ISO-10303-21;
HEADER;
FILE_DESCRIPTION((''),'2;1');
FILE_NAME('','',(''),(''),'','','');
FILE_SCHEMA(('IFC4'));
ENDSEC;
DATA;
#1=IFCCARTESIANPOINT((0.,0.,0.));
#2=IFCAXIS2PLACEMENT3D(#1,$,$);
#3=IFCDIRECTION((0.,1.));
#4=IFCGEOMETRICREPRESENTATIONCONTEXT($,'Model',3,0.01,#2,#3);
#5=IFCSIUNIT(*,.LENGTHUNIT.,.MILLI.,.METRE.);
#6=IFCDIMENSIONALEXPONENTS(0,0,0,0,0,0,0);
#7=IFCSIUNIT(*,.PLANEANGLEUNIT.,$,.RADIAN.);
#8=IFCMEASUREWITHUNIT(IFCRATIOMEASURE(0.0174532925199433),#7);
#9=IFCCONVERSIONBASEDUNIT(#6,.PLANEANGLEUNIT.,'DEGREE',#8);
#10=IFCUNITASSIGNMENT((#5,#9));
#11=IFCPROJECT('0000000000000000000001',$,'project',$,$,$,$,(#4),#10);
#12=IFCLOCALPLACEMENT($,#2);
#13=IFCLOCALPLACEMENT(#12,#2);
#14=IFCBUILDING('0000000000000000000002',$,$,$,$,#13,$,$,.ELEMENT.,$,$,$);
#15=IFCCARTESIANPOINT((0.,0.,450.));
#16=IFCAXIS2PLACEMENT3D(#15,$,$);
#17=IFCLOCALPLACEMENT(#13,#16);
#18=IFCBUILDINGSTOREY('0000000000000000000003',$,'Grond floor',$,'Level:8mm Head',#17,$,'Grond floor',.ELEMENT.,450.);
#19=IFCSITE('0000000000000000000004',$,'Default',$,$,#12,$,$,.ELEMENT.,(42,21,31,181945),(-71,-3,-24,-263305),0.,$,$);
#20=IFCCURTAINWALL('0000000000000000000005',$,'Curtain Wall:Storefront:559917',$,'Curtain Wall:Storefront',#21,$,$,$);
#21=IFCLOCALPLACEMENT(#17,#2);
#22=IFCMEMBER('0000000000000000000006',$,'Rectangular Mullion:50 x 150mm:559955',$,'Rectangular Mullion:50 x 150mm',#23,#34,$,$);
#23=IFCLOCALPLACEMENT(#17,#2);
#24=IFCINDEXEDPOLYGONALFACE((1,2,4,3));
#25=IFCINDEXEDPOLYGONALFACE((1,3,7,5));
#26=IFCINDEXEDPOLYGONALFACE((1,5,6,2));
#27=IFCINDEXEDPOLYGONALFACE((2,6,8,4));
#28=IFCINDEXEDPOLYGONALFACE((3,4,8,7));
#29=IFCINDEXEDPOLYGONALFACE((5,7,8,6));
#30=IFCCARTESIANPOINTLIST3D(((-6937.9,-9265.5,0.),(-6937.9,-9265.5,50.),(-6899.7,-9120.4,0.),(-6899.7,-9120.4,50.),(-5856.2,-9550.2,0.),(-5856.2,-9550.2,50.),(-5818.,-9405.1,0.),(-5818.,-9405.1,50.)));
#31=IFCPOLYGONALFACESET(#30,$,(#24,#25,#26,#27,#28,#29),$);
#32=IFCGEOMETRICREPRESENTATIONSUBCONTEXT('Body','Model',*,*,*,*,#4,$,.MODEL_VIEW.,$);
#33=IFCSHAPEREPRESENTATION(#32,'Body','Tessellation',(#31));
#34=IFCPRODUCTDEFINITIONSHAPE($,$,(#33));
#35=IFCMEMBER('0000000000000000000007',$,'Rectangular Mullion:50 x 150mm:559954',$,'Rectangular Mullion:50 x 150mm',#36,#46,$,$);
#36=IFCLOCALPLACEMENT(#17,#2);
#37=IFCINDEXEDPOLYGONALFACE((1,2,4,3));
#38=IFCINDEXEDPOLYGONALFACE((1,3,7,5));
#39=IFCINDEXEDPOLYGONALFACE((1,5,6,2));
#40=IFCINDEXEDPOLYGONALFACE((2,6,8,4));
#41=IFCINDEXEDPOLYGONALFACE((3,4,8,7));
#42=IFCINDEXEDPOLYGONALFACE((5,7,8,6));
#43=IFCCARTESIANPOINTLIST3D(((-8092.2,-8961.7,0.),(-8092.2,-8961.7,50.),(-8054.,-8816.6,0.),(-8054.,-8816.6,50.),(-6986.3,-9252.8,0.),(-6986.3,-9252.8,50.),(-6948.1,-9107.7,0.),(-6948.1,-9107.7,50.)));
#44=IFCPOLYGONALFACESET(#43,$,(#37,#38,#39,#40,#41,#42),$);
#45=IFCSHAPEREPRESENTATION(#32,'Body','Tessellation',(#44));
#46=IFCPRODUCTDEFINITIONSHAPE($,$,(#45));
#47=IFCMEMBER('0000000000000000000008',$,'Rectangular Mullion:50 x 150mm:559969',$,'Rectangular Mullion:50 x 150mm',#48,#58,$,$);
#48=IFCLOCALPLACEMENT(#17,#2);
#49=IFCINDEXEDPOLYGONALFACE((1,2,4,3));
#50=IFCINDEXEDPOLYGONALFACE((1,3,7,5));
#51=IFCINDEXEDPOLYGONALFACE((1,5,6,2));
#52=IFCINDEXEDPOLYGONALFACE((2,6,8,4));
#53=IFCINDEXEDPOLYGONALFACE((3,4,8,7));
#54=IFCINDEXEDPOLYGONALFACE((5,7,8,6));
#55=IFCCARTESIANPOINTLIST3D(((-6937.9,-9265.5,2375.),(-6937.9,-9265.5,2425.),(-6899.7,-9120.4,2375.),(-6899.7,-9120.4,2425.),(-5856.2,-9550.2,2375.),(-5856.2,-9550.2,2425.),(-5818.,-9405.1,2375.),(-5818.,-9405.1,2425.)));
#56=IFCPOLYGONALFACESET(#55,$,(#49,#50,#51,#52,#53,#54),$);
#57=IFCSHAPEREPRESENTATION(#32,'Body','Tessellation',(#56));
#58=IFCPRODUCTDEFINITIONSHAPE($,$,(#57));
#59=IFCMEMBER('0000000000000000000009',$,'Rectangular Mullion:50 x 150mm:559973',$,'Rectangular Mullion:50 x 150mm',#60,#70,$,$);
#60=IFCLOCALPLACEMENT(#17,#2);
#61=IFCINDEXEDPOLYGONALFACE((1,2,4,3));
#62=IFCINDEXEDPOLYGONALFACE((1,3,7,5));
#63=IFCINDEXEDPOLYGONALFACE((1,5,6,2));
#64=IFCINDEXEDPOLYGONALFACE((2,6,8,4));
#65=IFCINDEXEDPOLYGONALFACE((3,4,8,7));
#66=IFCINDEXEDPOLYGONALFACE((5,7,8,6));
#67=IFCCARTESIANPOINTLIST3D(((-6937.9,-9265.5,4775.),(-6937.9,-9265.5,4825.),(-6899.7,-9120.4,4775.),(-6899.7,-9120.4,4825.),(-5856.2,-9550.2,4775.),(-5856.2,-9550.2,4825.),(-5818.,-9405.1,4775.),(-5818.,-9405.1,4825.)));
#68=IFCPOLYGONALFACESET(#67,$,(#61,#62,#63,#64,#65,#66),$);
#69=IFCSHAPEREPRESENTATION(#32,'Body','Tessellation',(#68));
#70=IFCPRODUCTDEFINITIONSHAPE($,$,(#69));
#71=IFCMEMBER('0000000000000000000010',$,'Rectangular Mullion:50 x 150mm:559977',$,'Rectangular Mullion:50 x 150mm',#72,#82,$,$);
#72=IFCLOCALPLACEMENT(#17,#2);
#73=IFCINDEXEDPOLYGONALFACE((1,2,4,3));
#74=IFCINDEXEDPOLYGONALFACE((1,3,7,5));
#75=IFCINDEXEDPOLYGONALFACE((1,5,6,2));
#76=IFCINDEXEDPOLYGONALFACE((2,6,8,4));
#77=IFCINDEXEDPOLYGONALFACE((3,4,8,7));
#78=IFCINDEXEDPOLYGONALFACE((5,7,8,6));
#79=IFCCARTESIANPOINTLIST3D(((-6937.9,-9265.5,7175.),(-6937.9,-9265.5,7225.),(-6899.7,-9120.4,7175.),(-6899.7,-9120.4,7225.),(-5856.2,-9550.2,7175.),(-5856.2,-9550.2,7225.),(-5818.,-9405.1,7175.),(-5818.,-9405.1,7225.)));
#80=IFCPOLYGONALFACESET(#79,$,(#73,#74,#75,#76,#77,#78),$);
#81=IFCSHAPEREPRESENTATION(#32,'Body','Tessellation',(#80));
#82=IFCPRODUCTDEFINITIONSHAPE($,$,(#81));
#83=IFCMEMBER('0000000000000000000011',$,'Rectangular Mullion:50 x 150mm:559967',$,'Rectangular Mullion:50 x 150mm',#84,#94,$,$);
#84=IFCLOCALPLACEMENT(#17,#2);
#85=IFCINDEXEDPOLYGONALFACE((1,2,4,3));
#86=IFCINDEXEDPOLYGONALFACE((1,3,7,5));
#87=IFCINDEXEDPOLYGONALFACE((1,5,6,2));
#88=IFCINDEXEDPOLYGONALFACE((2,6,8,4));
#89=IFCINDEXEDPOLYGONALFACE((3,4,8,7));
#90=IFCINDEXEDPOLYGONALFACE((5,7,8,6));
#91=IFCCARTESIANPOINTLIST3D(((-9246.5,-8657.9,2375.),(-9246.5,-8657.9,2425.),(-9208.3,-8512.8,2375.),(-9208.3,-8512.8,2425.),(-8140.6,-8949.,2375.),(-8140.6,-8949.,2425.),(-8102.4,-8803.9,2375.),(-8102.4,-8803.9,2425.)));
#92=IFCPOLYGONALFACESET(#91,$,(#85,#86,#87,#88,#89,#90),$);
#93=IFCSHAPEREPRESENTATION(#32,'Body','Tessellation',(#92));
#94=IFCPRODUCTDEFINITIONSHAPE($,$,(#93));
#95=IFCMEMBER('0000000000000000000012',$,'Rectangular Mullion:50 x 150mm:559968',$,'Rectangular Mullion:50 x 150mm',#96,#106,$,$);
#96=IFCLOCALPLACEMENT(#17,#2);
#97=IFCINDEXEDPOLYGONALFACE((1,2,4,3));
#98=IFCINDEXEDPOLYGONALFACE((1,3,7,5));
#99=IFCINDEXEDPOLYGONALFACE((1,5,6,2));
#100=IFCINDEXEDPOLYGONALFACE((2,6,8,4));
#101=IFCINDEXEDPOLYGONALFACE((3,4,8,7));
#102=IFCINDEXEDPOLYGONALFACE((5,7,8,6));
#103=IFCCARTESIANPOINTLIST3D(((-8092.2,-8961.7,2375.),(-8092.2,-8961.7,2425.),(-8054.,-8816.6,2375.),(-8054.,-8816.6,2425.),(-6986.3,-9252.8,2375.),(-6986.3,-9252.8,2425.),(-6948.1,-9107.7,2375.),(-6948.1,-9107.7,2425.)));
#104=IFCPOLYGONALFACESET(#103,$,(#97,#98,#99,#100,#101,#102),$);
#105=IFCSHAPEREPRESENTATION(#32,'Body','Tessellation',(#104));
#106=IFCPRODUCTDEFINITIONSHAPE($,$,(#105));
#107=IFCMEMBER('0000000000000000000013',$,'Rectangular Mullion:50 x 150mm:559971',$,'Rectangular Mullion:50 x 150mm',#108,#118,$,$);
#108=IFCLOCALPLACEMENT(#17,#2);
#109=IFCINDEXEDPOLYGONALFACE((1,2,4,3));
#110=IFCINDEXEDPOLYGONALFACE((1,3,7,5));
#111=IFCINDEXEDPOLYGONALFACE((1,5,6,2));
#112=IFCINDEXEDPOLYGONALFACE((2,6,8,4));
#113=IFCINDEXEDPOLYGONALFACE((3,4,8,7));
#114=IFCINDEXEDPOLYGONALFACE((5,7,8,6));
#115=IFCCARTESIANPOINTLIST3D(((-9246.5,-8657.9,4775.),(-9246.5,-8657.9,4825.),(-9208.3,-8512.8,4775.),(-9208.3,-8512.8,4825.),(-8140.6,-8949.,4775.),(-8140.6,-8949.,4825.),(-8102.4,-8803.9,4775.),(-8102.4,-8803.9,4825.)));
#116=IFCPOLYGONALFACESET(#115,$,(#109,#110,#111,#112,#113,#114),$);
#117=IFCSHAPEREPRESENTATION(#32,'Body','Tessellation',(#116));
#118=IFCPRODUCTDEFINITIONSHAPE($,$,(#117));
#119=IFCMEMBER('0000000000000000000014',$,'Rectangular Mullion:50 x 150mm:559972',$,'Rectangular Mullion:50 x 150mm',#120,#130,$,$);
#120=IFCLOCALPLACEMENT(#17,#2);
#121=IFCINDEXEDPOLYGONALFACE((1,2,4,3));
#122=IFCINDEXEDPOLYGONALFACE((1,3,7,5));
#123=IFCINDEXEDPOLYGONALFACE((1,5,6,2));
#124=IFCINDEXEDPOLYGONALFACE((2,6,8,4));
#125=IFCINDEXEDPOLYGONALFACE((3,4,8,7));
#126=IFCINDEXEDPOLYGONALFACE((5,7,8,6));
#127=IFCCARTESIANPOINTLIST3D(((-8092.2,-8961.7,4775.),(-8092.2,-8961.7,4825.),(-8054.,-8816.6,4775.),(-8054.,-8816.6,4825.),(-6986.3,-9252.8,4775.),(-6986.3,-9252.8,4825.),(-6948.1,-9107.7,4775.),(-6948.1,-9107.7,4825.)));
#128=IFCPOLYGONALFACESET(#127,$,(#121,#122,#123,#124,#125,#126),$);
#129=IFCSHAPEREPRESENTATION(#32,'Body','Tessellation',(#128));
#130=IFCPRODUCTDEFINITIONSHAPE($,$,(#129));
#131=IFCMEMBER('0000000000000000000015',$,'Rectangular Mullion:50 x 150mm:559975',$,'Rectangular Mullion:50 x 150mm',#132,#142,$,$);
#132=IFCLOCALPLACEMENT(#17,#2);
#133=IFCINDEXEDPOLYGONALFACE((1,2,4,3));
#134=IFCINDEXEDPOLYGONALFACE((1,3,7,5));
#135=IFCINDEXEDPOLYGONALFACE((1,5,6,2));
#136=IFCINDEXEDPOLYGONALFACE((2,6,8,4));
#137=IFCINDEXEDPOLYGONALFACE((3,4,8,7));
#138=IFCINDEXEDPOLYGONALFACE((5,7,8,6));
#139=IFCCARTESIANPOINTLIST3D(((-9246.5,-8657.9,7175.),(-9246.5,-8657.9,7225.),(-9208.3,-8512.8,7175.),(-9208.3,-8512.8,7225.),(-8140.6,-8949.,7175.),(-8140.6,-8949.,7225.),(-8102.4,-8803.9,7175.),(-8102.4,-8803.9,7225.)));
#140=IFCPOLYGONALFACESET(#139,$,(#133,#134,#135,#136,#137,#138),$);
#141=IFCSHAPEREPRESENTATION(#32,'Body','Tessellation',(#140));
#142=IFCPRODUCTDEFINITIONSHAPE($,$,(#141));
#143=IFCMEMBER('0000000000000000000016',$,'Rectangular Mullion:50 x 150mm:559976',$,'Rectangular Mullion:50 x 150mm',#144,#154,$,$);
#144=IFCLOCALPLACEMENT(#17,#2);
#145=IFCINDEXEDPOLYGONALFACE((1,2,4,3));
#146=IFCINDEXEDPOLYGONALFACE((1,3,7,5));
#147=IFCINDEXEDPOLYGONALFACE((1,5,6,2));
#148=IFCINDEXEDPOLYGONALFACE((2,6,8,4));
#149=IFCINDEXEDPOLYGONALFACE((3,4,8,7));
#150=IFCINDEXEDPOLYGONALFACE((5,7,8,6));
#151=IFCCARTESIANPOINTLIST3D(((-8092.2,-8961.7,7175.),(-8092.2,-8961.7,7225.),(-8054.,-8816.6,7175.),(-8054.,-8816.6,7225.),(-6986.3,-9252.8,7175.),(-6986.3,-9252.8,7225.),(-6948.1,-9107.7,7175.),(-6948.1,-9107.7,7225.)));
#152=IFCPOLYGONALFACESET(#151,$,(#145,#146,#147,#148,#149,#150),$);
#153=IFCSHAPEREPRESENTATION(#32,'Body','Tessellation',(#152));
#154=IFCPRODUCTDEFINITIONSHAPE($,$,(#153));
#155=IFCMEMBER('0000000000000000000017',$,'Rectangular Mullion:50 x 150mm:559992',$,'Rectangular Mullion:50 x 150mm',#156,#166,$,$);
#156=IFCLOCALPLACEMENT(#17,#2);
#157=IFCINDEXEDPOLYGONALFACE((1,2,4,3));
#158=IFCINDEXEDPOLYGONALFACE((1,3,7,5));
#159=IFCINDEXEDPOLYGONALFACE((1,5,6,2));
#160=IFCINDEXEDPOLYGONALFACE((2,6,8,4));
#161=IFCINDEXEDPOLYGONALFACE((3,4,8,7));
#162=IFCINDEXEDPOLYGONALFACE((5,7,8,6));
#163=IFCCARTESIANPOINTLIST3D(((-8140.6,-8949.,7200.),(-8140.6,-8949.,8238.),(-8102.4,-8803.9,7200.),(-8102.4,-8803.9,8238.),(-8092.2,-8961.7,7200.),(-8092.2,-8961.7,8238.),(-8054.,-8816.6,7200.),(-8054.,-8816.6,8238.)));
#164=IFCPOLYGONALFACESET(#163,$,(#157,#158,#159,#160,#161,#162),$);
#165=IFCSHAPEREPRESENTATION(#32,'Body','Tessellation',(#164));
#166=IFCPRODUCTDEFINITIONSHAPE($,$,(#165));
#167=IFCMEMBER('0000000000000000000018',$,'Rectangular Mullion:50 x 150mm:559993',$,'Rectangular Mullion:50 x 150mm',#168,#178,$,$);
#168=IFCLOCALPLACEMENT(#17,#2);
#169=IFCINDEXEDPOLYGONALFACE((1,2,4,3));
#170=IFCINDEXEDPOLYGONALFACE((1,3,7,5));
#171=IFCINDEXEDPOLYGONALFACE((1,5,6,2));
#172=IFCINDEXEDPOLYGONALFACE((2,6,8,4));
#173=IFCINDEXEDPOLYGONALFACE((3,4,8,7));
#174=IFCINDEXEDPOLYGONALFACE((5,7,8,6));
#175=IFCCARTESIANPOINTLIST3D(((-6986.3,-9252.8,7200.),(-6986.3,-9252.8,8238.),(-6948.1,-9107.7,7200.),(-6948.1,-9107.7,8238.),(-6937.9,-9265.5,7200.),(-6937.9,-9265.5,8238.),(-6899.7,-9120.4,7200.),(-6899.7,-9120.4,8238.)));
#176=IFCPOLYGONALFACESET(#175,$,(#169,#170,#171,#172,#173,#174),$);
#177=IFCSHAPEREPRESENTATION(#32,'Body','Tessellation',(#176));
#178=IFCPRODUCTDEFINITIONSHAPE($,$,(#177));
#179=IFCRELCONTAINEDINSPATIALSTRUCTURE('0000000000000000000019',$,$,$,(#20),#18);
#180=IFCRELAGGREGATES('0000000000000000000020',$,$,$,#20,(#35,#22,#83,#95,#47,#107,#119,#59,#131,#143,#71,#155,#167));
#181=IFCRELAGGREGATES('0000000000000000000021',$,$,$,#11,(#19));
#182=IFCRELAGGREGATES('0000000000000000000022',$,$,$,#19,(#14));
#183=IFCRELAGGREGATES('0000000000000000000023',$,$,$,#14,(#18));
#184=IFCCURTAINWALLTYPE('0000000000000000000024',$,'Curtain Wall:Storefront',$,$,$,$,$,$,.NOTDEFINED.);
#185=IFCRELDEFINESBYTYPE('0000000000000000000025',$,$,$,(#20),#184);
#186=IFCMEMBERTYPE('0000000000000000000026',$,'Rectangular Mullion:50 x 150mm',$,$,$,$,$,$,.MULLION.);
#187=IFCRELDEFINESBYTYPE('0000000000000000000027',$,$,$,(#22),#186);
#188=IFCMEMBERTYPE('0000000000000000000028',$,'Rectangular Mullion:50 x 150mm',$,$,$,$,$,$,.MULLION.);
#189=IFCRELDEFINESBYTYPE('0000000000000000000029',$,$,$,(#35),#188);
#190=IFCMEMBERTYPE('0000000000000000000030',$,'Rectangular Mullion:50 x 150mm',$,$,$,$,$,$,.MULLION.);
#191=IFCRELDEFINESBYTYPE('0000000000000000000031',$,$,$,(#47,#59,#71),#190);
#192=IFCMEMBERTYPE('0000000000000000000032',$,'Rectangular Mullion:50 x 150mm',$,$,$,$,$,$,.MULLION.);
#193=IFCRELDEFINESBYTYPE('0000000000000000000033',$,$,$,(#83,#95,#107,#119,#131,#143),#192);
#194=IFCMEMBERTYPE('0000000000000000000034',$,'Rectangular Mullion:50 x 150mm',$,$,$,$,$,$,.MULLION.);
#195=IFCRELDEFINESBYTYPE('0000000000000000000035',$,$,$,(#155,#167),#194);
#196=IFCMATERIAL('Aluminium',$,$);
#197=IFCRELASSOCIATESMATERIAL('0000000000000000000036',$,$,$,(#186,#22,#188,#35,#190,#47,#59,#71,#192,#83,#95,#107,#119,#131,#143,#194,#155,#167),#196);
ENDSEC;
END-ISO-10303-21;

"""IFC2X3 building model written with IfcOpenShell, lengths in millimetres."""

from ifc_helpers import new_model, entity, si_unit, converted_unit, direction, frame, frame_2d, origin, origin_2d_with_axis, place, context, subcontext, project, spatial, rectangle, extrude, source, transform, mapped, material, type_object, type_shapes, element, aggregate, save


model = new_model("IFC2X3")

# Units and contexts
model_context = context("Model", 3, precision=0.01, world=origin(), true_north=direction((0.0, 1.0)))
body_context = subcontext(model_context, "Body", "Model", "MODEL_VIEW")
ifc_project = project(units=[si_unit("LENGTHUNIT", "METRE", prefix="MILLI"), converted_unit("PLANEANGLEUNIT", "DEGREE", entity("IfcRatioMeasure", 0.0174532925199433), si_unit("PLANEANGLEUNIT", "RADIAN"), dimensions=[0, 0, 0, 0, 0, 0, 0])], contexts=[model_context])

# Site, building, storey
site_placement = place(None, origin())
site = spatial("IfcSite", under=ifc_project, at=site_placement, Name="Default", CompositionType="ELEMENT", RefLatitude=(42, 21, 31, 181945), RefLongitude=(-71, -3, -24, -263305), RefElevation=0.0)
building_placement = place(site_placement, origin())
building = spatial("IfcBuilding", under=site, at=building_placement, CompositionType="ELEMENT")
storey_placement = place(building_placement, frame((0.0, 0.0, 450.0)))
storey = spatial("IfcBuildingStorey", under=building, at=storey_placement, Name="Grond floor", ObjectType="Level:8mm Head", LongName="Grond floor", CompositionType="ELEMENT", Elevation=450.0)

# Curtain wall, members
curtain_wall_type = type_object("IfcCurtainWallType", Name="Curtain Wall:Storefront", PredefinedType="NOTDEFINED")
curtain_wall_placement = place(storey_placement, frame((0.0, 0.0, -450.0)))
curtain_wall = element("IfcCurtainWall", 1, at=curtain_wall_placement, inside=storey, type_object=curtain_wall_type, Name="Curtain Wall:Storefront:559917", ObjectType="Curtain Wall:Storefront")
ifc_material_1 = material(Name="Aluminium")
member_type_1 = type_object("IfcMemberType", Name="Rectangular Mullion:50 x 150mm", PredefinedType="MULLION", material=ifc_material_1)
shared_shape_1 = source(origin(), body_context, "Body", "SweptSolid", [
    extrude(rectangle(XDim=150.0, YDim=50.0, at=origin_2d_with_axis()), frame((-25.0, 0.0, -1118.6), z_axis=(0.0, 0.0, 1.0), x_axis=(0.0, -1.0, 0.0)), (0.0, 0.0, 1.0), 1118.6),
])
type_shapes(member_type_1, [shared_shape_1])
member_1_placement = place(storey_placement, frame((-6918.8, -9193.0, 0.0), z_axis=(-0.967067, 0.25452, 0.0), x_axis=(0.0, 0.0, -1.0)))
member_1 = element("IfcMember", 2, at=member_1_placement, type_object=member_type_1, material=ifc_material_1, Name="Rectangular Mullion:50 x 150mm:559955", ObjectType="Rectangular Mullion:50 x 150mm", context=body_context, shape_type="MappedRepresentation", body=[
    mapped(shared_shape_1, transform((0.0, 0.0, 0.0), scale=1.0)),
])
member_type_2 = type_object("IfcMemberType", Name="Rectangular Mullion:50 x 150mm", PredefinedType="MULLION", material=ifc_material_1)
shared_shape_2 = source(origin(), body_context, "Body", "SweptSolid", [
    extrude(rectangle(XDim=150.0, YDim=50.0, at=frame_2d((0.0, 0.0), x_axis=(1.0, 0.0))), frame((-25.0, 0.0, -1143.6), z_axis=(0.0, 0.0, 1.0), x_axis=(0.0, -1.0, 0.0)), (0.0, 0.0, 1.0), 1143.6),
])
type_shapes(member_type_2, [shared_shape_2])
member_2_placement = place(storey_placement, frame((-8073.1, -8889.2, 0.0), z_axis=(-0.967067, 0.25452, 0.0), x_axis=(0.0, 0.0, -1.0)))
member_2 = element("IfcMember", 3, at=member_2_placement, type_object=member_type_2, material=ifc_material_1, Name="Rectangular Mullion:50 x 150mm:559954", ObjectType="Rectangular Mullion:50 x 150mm", context=body_context, shape_type="MappedRepresentation", body=[
    mapped(shared_shape_2, transform((0.0, 0.0, 0.0), scale=1.0)),
])
member_type_3 = type_object("IfcMemberType", Name="Rectangular Mullion:50 x 150mm", PredefinedType="MULLION", material=ifc_material_1)
shared_shape_3 = source(origin(), body_context, "Body", "SweptSolid", [
    extrude(rectangle(XDim=150.0, YDim=50.0, at=origin_2d_with_axis()), frame((0.0, 0.0, -1118.6), z_axis=(0.0, 0.0, 1.0), x_axis=(0.0, -1.0, 0.0)), (0.0, 0.0, 1.0), 1118.6),
])
type_shapes(member_type_3, [shared_shape_3])
member_3_placement = place(storey_placement, frame((-5837.1, -9477.7, 2400.0), z_axis=(0.967067, -0.25452, 0.0), x_axis=(0.0, 0.0, 1.0)))
member_3 = element("IfcMember", 4, at=member_3_placement, type_object=member_type_3, material=ifc_material_1, Name="Rectangular Mullion:50 x 150mm:559969", ObjectType="Rectangular Mullion:50 x 150mm", context=body_context, shape_type="MappedRepresentation", body=[
    mapped(shared_shape_3, transform((0.0, 0.0, 0.0), scale=1.0)),
])
member_4_placement = place(storey_placement, frame((-5837.1, -9477.7, 4800.0), z_axis=(0.967067, -0.25452, 0.0), x_axis=(0.0, 0.0, 1.0)))
member_4 = element("IfcMember", 5, at=member_4_placement, type_object=member_type_3, material=ifc_material_1, Name="Rectangular Mullion:50 x 150mm:559973", ObjectType="Rectangular Mullion:50 x 150mm", context=body_context, shape_type="MappedRepresentation", body=[
    mapped(shared_shape_3, transform((0.0, 0.0, 0.0), scale=1.0)),
])
member_5_placement = place(storey_placement, frame((-5837.1, -9477.7, 7200.0), z_axis=(0.967067, -0.25452, 0.0), x_axis=(0.0, 0.0, 1.0)))
member_5 = element("IfcMember", 6, at=member_5_placement, type_object=member_type_3, material=ifc_material_1, Name="Rectangular Mullion:50 x 150mm:559977", ObjectType="Rectangular Mullion:50 x 150mm", context=body_context, shape_type="MappedRepresentation", body=[
    mapped(shared_shape_3, transform((0.0, 0.0, 0.0), scale=1.0)),
])
member_type_4 = type_object("IfcMemberType", Name="Rectangular Mullion:50 x 150mm", PredefinedType="MULLION", material=ifc_material_1)
shared_shape_4 = source(origin(), body_context, "Body", "SweptSolid", [
    extrude(rectangle(XDim=150.0, YDim=50.0, at=frame_2d((0.0, 0.0), x_axis=(1.0, 0.0))), frame((0.0, 0.0, -1143.6), z_axis=(0.0, 0.0, 1.0), x_axis=(0.0, -1.0, 0.0)), (0.0, 0.0, 1.0), 1143.6),
])
type_shapes(member_type_4, [shared_shape_4])
member_6_placement = place(storey_placement, frame((-8121.5, -8876.4, 2400.0), z_axis=(0.967067, -0.25452, 0.0), x_axis=(0.0, 0.0, 1.0)))
member_6 = element("IfcMember", 7, at=member_6_placement, type_object=member_type_4, material=ifc_material_1, Name="Rectangular Mullion:50 x 150mm:559967", ObjectType="Rectangular Mullion:50 x 150mm", context=body_context, shape_type="MappedRepresentation", body=[
    mapped(shared_shape_4, transform((0.0, 0.0, 0.0), scale=1.0)),
])
member_7_placement = place(storey_placement, frame((-6967.2, -9180.2, 2400.0), z_axis=(0.967067, -0.25452, 0.0), x_axis=(0.0, 0.0, 1.0)))
member_7 = element("IfcMember", 8, at=member_7_placement, type_object=member_type_4, material=ifc_material_1, Name="Rectangular Mullion:50 x 150mm:559968", ObjectType="Rectangular Mullion:50 x 150mm", context=body_context, shape_type="MappedRepresentation", body=[
    mapped(shared_shape_4, transform((0.0, 0.0, 0.0), scale=1.0)),
])
member_8_placement = place(storey_placement, frame((-8121.5, -8876.4, 4800.0), z_axis=(0.967067, -0.25452, 0.0), x_axis=(0.0, 0.0, 1.0)))
member_8 = element("IfcMember", 9, at=member_8_placement, type_object=member_type_4, material=ifc_material_1, Name="Rectangular Mullion:50 x 150mm:559971", ObjectType="Rectangular Mullion:50 x 150mm", context=body_context, shape_type="MappedRepresentation", body=[
    mapped(shared_shape_4, transform((0.0, 0.0, 0.0), scale=1.0)),
])
member_9_placement = place(storey_placement, frame((-6967.2, -9180.2, 4800.0), z_axis=(0.967067, -0.25452, 0.0), x_axis=(0.0, 0.0, 1.0)))
member_9 = element("IfcMember", 10, at=member_9_placement, type_object=member_type_4, material=ifc_material_1, Name="Rectangular Mullion:50 x 150mm:559972", ObjectType="Rectangular Mullion:50 x 150mm", context=body_context, shape_type="MappedRepresentation", body=[
    mapped(shared_shape_4, transform((0.0, 0.0, 0.0), scale=1.0)),
])
member_10_placement = place(storey_placement, frame((-8121.5, -8876.4, 7200.0), z_axis=(0.967067, -0.25452, 0.0), x_axis=(0.0, 0.0, 1.0)))
member_10 = element("IfcMember", 11, at=member_10_placement, type_object=member_type_4, material=ifc_material_1, Name="Rectangular Mullion:50 x 150mm:559975", ObjectType="Rectangular Mullion:50 x 150mm", context=body_context, shape_type="MappedRepresentation", body=[
    mapped(shared_shape_4, transform((0.0, 0.0, 0.0), scale=1.0)),
])
member_11_placement = place(storey_placement, frame((-6967.2, -9180.2, 7200.0), z_axis=(0.967067, -0.25452, 0.0), x_axis=(0.0, 0.0, 1.0)))
member_11 = element("IfcMember", 12, at=member_11_placement, type_object=member_type_4, material=ifc_material_1, Name="Rectangular Mullion:50 x 150mm:559976", ObjectType="Rectangular Mullion:50 x 150mm", context=body_context, shape_type="MappedRepresentation", body=[
    mapped(shared_shape_4, transform((0.0, 0.0, 0.0), scale=1.0)),
])
member_type_5 = type_object("IfcMemberType", Name="Rectangular Mullion:50 x 150mm", PredefinedType="MULLION", material=ifc_material_1)
shared_shape_5 = source(origin(), body_context, "Body", "SweptSolid", [
    extrude(rectangle(XDim=150.0, YDim=50.0, at=origin_2d_with_axis()), frame((0.0, 0.0, -1038.0), z_axis=(0.0, 0.0, 1.0), x_axis=(0.0, -1.0, 0.0)), (0.0, 0.0, 1.0), 1038.0),
])
type_shapes(member_type_5, [shared_shape_5])
member_12_placement = place(storey_placement, frame((-8097.3, -8882.8, 7200.0), z_axis=(0.0, 0.0, -1.0), x_axis=(0.967067, -0.25452, 0.0)))
member_12 = element("IfcMember", 13, at=member_12_placement, type_object=member_type_5, material=ifc_material_1, Name="Rectangular Mullion:50 x 150mm:559992", ObjectType="Rectangular Mullion:50 x 150mm", context=body_context, shape_type="MappedRepresentation", body=[
    mapped(shared_shape_5, transform((0.0, 0.0, 0.0), scale=1.0)),
])
member_13_placement = place(storey_placement, frame((-6943.0, -9186.6, 7200.0), z_axis=(0.0, 0.0, -1.0), x_axis=(0.967067, -0.25452, 0.0)))
member_13 = element("IfcMember", 14, at=member_13_placement, type_object=member_type_5, material=ifc_material_1, Name="Rectangular Mullion:50 x 150mm:559993", ObjectType="Rectangular Mullion:50 x 150mm", context=body_context, shape_type="MappedRepresentation", body=[
    mapped(shared_shape_5, transform((0.0, 0.0, 0.0), scale=1.0)),
])

aggregate(curtain_wall, [member_2, member_1, member_6, member_7, member_3, member_8, member_9, member_4, member_10, member_11, member_5, member_12, member_13])

save(model, "model.ifc")
